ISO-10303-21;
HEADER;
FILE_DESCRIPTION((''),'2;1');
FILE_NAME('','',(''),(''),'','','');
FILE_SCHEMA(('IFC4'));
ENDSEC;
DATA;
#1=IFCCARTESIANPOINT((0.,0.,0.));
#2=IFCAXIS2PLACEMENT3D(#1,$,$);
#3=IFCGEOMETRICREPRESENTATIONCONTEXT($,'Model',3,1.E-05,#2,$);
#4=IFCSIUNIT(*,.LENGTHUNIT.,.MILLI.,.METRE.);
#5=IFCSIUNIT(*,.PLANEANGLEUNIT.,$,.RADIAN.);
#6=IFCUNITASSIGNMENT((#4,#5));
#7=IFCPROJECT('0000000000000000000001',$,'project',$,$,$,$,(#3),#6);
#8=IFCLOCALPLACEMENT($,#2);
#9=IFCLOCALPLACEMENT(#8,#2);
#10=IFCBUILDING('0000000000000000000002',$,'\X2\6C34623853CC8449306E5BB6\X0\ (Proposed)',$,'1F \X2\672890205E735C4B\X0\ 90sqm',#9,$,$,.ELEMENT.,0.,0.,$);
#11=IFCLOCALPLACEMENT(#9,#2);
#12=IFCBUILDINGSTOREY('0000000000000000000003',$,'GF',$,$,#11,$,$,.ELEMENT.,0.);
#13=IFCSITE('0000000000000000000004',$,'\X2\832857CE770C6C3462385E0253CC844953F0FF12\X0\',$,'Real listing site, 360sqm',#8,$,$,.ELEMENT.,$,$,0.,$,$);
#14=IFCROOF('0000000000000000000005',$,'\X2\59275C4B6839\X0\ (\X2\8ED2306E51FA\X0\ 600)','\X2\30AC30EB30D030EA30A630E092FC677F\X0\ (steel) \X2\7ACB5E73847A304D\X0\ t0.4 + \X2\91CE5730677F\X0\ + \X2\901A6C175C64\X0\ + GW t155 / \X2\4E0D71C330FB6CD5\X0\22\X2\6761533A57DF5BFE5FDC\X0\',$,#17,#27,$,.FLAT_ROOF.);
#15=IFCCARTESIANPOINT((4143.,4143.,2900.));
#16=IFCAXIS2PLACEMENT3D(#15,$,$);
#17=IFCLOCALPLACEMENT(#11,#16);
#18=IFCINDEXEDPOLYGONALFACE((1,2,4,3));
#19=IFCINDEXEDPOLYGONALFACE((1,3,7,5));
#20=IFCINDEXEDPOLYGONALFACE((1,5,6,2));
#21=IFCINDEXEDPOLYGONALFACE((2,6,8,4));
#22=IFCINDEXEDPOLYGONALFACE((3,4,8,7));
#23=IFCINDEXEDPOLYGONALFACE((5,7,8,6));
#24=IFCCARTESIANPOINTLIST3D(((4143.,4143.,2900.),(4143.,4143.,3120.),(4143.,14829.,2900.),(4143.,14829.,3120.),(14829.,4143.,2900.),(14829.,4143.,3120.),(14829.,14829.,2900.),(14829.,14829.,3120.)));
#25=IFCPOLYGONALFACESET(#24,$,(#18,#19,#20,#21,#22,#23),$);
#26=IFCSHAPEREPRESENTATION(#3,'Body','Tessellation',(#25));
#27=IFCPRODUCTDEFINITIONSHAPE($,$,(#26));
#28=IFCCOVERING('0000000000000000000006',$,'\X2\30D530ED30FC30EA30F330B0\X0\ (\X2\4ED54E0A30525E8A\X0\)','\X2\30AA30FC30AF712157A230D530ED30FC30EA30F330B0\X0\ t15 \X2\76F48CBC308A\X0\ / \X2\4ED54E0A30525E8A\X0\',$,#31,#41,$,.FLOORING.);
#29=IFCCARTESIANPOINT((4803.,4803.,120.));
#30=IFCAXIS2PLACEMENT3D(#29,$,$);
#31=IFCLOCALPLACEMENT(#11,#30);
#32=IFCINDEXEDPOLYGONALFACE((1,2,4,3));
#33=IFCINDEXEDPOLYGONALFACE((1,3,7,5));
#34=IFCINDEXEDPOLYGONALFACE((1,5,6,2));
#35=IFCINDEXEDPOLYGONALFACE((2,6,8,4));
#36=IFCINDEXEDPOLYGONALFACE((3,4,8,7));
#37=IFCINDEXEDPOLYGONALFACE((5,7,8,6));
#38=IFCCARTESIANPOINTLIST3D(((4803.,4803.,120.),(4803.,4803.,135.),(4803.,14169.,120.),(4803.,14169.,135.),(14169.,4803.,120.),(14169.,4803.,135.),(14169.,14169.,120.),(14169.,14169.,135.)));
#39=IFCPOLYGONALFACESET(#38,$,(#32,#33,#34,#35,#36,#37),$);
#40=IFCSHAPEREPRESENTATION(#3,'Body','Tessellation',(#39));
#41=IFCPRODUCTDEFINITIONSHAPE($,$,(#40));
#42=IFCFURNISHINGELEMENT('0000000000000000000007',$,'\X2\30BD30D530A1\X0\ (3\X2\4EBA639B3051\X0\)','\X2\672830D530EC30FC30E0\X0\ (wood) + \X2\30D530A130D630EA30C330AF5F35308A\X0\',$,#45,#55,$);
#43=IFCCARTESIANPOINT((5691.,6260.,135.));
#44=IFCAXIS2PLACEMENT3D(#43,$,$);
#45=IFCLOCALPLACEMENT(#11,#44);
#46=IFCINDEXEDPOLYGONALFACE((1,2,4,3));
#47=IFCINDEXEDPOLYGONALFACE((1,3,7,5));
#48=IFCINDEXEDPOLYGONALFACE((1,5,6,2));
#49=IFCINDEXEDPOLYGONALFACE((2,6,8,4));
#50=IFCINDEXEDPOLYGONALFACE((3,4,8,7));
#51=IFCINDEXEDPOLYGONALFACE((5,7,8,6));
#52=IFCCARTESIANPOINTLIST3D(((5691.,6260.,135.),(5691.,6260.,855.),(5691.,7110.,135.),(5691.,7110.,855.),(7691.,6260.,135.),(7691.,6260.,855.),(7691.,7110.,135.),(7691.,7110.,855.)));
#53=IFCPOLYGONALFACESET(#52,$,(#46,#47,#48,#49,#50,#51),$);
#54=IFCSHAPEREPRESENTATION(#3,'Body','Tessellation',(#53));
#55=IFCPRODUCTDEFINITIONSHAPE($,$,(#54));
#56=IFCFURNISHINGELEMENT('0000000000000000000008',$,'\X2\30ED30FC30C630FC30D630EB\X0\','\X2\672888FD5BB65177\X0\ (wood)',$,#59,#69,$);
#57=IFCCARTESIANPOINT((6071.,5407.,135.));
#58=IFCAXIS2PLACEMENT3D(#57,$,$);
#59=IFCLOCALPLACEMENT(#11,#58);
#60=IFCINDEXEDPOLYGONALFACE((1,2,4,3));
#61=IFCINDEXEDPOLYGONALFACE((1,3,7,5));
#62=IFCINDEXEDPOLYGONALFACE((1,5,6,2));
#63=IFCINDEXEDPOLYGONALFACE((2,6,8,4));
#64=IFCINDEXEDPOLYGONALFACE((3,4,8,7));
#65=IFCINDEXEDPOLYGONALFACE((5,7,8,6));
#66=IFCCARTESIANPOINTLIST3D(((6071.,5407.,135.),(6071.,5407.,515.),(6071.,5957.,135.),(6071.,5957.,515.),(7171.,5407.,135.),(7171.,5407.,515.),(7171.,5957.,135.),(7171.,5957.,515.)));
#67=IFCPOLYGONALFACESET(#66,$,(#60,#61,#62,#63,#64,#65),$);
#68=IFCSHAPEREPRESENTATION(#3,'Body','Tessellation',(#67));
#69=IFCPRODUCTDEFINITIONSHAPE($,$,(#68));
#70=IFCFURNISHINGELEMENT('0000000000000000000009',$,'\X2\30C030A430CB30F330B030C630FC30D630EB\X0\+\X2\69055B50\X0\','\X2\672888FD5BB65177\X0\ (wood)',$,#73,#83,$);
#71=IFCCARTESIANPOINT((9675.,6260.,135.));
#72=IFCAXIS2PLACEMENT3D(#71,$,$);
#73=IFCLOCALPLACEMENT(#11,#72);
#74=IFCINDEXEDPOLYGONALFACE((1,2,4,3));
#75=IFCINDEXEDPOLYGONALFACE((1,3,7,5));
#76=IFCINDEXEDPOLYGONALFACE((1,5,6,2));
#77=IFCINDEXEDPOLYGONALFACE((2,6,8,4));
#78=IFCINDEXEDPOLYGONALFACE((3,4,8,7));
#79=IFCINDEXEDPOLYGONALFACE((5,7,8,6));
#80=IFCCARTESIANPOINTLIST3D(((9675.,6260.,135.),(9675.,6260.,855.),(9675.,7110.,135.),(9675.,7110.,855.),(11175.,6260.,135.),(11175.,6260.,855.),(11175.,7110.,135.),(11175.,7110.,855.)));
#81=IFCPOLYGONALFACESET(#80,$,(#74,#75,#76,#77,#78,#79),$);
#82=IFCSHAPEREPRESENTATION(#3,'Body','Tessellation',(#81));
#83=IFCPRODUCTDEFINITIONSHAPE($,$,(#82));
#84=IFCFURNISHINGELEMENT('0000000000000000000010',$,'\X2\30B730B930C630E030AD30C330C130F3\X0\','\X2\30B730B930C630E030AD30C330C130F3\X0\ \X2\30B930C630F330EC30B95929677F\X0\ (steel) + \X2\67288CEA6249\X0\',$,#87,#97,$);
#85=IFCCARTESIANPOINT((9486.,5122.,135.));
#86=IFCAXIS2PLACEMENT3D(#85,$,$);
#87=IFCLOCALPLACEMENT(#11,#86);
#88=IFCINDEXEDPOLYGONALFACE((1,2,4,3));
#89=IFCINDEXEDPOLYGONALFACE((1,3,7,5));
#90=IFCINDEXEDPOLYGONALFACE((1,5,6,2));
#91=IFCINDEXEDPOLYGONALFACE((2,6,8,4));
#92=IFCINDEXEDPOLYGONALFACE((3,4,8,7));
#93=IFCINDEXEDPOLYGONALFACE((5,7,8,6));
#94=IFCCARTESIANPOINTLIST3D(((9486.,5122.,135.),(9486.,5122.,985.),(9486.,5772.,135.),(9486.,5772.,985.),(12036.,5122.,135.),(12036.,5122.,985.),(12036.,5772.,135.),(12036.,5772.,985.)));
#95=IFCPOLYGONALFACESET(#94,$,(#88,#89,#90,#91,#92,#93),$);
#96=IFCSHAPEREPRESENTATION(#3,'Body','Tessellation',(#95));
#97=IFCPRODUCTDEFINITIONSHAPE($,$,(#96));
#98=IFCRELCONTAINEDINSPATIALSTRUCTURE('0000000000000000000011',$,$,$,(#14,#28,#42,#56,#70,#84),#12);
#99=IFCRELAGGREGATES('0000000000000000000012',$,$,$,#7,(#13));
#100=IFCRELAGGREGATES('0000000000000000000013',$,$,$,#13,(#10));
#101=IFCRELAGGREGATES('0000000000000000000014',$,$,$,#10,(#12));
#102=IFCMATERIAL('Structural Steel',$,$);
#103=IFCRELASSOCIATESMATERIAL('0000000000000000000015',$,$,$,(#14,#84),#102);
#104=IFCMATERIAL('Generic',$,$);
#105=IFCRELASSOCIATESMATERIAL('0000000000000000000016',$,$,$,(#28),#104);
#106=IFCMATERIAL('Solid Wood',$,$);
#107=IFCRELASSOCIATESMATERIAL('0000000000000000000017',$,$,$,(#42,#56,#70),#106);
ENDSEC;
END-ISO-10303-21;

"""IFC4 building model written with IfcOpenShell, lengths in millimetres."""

from ifc_helpers import new_model, si_unit, frame, frame_2d, origin, place, context, project, spatial, rectangle, extrude, material, element, save


model = new_model("IFC4")

# Units and contexts
model_context = context("Model", 3, precision=1e-05, world=origin())
ifc_project = project(units=[si_unit("LENGTHUNIT", "METRE", prefix="MILLI"), si_unit("PLANEANGLEUNIT", "RADIAN")], contexts=[model_context])

# Site, building, storey
site_placement = place(None, origin())
site = spatial("IfcSite", under=ifc_project, at=site_placement, Name="茨城県水戸市双葉台２", ObjectType="Real listing site, 360sqm", CompositionType="ELEMENT", RefElevation=0.0)
building_placement = place(site_placement, origin())
building = spatial("IfcBuilding", under=site, at=building_placement, Name="水戸双葉の家 (Proposed)", ObjectType="1F 木造平屋 90sqm", CompositionType="ELEMENT", ElevationOfRefHeight=0.0, ElevationOfTerrain=0.0)
storey_placement = place(building_placement, origin())
storey = spatial("IfcBuildingStorey", under=building, at=storey_placement, Name="GF", CompositionType="ELEMENT", Elevation=0.0)

# Shared definitions
ifc_material_1 = material(Name="Solid Wood")

# Roof
ifc_material_2 = material(Name="Structural Steel")
roof_placement = place(storey_placement, frame((4143.0, 4143.0, 2900.0)))
element("IfcRoof", 1, at=roof_placement, inside=storey, material=ifc_material_2, Name="大屋根 (軒の出 600)", Description="ガルバリウム鋼板 (steel) 立平葺き t0.4 + 野地板 + 通気層 + GW t155 / 不燃・法22条区域対応", PredefinedType="FLAT_ROOF", context=model_context, shape_type="SweptSolid", body=[
    extrude(rectangle(XDim=10686.0, YDim=10686.0, at=frame_2d((5343.0, 5343.0))), frame((4143.0, 4143.0, 2900.0)), (0.0, 0.0, 1.0), 220.0),
])

# Covering
ifc_material_3 = material(Name="Generic")
covering_placement = place(storey_placement, frame((4803.0, 4803.0, 120.0)))
element("IfcCovering", 2, at=covering_placement, inside=storey, material=ifc_material_3, Name="フローリング (仕上げ床)", Description="オーク無垢フローリング t15 直貼り / 仕上げ床", PredefinedType="FLOORING", context=model_context, shape_type="SweptSolid", body=[
    extrude(rectangle(XDim=9366.0, YDim=9366.0, at=frame_2d((4683.0, 4683.0))), frame((4803.0, 4803.0, 120.0)), (0.0, 0.0, 1.0), 15.0),
])

# Furnishing elements
furnishing_1_placement = place(storey_placement, frame((5691.0, 6260.0, 135.0)))
element("IfcFurnishingElement", 3, at=furnishing_1_placement, inside=storey, material=ifc_material_1, Name="ソファ (3人掛け)", Description="木フレーム (wood) + ファブリック張り", context=model_context, shape_type="SweptSolid", body=[
    extrude(rectangle(XDim=2000.0, YDim=850.0, at=frame_2d((1000.0, 425.0))), frame((5691.0, 6260.0, 135.0)), (0.0, 0.0, 1.0), 720.0),
])
furnishing_2_placement = place(storey_placement, frame((6071.0, 5407.0, 135.0)))
element("IfcFurnishingElement", 4, at=furnishing_2_placement, inside=storey, material=ifc_material_1, Name="ローテーブル", Description="木製家具 (wood)", context=model_context, shape_type="SweptSolid", body=[
    extrude(rectangle(XDim=1100.0, YDim=550.0, at=frame_2d((550.0, 275.0))), frame((6071.0, 5407.0, 135.0)), (0.0, 0.0, 1.0), 380.0),
])
furnishing_3_placement = place(storey_placement, frame((9675.0, 6260.0, 135.0)))
element("IfcFurnishingElement", 5, at=furnishing_3_placement, inside=storey, material=ifc_material_1, Name="ダイニングテーブル+椅子", Description="木製家具 (wood)", context=model_context, shape_type="SweptSolid", body=[
    extrude(rectangle(XDim=1500.0, YDim=850.0, at=frame_2d((750.0, 425.0))), frame((9675.0, 6260.0, 135.0)), (0.0, 0.0, 1.0), 720.0),
])
furnishing_4_placement = place(storey_placement, frame((9486.0, 5122.0, 135.0)))
element("IfcFurnishingElement", 6, at=furnishing_4_placement, inside=storey, material=ifc_material_2, Name="システムキッチン", Description="システムキッチン ステンレス天板 (steel) + 木質扉", context=model_context, shape_type="SweptSolid", body=[
    extrude(rectangle(XDim=2550.0, YDim=650.0, at=frame_2d((1275.0, 325.0))), frame((9486.0, 5122.0, 135.0)), (0.0, 0.0, 1.0), 850.0),
])

save(model, "model.ifc")
